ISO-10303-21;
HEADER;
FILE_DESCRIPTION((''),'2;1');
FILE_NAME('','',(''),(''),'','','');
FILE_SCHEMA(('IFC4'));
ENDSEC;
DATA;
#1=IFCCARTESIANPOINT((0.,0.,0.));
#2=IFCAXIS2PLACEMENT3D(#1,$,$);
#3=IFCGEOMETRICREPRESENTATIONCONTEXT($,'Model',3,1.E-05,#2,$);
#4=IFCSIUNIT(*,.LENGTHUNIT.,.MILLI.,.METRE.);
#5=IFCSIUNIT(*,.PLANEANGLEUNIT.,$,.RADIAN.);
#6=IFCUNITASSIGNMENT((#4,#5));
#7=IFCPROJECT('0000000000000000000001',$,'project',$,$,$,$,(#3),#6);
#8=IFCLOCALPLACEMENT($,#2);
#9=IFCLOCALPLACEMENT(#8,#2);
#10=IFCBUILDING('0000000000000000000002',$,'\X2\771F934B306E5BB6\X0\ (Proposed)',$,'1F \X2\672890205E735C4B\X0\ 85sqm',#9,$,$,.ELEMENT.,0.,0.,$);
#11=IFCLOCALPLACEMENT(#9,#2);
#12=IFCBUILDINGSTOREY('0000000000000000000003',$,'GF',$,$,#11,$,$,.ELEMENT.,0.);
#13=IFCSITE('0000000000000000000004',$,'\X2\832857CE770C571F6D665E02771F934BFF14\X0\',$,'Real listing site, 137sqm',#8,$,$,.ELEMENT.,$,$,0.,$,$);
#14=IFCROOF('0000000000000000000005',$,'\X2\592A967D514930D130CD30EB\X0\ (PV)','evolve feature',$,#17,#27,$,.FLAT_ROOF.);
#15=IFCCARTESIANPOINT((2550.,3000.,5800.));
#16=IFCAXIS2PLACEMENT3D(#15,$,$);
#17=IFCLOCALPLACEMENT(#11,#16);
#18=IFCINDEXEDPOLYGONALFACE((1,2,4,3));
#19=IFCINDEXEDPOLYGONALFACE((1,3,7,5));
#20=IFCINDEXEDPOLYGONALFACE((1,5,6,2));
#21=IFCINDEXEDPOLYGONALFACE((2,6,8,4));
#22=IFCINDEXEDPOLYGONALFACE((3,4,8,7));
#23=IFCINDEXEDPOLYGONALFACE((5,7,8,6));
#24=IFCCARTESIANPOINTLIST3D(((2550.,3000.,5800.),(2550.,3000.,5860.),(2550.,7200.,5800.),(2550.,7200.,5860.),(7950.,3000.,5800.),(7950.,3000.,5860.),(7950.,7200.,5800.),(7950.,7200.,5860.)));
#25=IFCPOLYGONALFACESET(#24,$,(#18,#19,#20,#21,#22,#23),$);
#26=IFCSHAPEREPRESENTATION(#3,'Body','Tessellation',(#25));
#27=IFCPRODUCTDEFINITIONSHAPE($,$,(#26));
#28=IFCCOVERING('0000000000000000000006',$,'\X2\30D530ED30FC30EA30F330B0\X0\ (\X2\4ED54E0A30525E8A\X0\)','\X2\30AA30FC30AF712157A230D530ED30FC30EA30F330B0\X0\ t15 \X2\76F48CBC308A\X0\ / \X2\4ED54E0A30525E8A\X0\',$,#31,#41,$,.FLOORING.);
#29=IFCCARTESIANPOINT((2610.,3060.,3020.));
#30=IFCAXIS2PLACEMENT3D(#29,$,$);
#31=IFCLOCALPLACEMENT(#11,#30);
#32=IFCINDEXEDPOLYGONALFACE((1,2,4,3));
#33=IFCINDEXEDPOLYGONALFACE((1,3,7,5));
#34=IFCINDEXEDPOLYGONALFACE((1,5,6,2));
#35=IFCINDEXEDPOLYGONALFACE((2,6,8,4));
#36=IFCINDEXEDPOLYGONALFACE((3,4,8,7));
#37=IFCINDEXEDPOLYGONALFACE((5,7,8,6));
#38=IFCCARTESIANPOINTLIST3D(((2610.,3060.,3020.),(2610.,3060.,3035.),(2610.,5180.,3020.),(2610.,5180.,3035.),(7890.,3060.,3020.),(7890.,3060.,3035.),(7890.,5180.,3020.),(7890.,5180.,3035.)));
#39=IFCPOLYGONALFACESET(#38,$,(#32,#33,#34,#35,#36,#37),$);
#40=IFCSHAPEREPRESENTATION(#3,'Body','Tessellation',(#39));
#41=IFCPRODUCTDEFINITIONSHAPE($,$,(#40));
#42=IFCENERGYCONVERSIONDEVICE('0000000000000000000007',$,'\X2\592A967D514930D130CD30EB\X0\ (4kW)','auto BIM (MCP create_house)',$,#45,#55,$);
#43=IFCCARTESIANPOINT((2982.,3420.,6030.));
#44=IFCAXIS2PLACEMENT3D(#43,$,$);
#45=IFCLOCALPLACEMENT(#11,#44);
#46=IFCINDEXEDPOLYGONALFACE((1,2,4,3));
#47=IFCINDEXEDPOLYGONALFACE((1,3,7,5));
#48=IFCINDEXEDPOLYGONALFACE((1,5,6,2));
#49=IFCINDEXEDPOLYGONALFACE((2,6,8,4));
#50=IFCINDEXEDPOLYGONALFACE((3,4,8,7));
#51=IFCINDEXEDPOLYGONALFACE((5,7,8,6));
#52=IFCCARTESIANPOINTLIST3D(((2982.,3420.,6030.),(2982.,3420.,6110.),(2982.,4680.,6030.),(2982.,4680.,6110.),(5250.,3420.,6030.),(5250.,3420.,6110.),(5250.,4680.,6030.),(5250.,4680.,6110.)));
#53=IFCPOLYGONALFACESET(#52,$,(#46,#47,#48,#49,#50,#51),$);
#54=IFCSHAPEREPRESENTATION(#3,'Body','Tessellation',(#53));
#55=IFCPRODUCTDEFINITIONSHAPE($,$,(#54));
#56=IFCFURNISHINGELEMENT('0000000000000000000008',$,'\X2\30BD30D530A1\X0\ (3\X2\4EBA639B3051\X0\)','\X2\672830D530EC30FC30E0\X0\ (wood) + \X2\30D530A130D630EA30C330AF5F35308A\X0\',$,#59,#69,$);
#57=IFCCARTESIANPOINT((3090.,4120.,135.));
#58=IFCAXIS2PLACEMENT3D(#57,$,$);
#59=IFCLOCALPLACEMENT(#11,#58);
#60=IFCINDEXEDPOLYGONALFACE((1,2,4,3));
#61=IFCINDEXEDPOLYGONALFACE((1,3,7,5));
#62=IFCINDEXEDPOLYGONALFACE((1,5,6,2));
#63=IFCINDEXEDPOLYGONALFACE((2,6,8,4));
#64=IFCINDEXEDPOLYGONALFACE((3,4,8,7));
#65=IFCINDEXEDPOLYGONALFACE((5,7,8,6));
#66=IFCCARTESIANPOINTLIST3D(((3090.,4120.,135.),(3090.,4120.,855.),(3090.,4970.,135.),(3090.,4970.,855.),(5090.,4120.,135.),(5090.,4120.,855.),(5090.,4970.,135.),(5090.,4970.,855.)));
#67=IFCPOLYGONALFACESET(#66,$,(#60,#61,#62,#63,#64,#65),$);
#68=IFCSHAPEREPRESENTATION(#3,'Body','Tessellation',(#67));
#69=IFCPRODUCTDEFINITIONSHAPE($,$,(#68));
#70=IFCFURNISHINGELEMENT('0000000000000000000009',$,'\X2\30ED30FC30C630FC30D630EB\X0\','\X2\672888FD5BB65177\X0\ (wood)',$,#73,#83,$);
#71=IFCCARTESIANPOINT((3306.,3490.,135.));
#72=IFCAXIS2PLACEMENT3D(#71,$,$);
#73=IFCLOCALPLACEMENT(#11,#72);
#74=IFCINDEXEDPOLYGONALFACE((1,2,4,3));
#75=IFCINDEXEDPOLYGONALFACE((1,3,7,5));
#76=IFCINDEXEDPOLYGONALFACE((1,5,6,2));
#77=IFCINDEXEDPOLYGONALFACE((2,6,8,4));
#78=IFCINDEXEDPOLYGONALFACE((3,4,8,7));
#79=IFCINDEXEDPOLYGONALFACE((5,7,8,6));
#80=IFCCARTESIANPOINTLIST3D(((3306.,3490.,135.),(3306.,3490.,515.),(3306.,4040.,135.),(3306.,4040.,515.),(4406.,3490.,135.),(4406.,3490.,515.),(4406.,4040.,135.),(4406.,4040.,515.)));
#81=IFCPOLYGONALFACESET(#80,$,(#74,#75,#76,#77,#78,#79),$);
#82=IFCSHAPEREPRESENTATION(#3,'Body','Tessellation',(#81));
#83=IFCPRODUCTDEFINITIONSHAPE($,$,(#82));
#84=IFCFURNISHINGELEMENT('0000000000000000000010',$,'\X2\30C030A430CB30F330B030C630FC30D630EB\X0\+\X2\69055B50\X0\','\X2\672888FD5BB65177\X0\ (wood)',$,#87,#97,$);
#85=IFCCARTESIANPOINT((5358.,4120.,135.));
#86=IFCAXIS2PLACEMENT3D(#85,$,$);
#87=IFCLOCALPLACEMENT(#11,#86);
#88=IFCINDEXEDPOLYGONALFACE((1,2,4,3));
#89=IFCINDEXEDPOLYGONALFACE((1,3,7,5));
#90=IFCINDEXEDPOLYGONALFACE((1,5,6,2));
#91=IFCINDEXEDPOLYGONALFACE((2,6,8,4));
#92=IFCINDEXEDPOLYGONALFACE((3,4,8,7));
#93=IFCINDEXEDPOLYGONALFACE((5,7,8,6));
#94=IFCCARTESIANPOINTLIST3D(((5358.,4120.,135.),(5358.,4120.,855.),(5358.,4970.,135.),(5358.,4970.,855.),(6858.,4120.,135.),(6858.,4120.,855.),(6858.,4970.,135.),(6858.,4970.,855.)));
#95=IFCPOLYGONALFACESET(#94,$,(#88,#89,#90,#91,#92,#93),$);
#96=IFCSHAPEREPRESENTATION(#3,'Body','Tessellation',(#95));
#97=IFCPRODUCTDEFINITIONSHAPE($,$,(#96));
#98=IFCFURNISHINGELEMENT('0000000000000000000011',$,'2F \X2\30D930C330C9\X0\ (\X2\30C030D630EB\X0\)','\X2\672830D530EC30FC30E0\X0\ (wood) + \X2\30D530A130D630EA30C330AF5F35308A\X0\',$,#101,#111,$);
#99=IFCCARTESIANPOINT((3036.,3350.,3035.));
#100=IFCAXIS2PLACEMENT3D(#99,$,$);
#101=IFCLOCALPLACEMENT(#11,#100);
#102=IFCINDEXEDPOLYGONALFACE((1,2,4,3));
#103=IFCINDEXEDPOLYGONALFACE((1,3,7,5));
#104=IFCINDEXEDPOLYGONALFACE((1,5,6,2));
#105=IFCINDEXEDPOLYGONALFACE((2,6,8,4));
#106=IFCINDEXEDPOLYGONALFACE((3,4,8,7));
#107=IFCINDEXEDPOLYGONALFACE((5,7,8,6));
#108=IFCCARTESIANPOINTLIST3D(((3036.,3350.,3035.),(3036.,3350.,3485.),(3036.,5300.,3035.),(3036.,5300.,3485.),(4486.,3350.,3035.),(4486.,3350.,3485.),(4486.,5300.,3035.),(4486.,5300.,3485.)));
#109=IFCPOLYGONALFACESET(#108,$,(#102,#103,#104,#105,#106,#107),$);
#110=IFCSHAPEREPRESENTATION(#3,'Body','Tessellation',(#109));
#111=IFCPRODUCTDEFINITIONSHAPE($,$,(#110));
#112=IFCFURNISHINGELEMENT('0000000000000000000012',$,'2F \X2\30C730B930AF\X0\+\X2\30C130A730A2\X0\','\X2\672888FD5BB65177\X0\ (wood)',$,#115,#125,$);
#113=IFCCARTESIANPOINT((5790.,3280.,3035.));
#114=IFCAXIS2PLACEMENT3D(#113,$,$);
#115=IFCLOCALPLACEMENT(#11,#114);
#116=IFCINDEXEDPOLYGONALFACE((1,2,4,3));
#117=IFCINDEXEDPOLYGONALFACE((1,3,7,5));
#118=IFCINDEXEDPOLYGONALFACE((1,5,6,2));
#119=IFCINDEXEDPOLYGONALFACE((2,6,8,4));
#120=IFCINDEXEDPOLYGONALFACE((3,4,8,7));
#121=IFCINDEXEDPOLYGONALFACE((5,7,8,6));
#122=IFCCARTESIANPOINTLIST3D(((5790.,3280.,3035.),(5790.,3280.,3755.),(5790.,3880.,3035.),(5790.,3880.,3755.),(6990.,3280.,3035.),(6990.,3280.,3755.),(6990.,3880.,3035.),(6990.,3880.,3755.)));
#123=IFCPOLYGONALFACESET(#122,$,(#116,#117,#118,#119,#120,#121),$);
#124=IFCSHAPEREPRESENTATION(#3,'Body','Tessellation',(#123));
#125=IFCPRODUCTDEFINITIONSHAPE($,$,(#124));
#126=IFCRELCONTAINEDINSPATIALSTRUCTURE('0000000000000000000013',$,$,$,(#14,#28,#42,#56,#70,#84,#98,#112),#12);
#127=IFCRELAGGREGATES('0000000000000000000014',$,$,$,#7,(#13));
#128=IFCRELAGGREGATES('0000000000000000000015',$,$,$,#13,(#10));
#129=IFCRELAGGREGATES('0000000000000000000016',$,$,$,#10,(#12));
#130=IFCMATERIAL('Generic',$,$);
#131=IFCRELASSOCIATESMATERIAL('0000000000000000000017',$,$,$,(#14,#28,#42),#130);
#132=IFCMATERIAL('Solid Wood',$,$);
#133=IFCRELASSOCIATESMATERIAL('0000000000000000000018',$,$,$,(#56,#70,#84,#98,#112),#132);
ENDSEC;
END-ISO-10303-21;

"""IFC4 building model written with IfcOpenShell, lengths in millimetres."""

from ifc_helpers import new_model, si_unit, frame, frame_2d, origin, place, context, project, spatial, rectangle, extrude, material, element, save


model = new_model("IFC4")

# Units and contexts
model_context = context("Model", 3, precision=1e-05, world=origin())
ifc_project = project(units=[si_unit("LENGTHUNIT", "METRE", prefix="MILLI"), si_unit("PLANEANGLEUNIT", "RADIAN")], contexts=[model_context])

# Site, building, storey
site_placement = place(None, origin())
site = spatial("IfcSite", under=ifc_project, at=site_placement, Name="茨城県土浦市真鍋４", ObjectType="Real listing site, 137sqm", CompositionType="ELEMENT", RefElevation=0.0)
building_placement = place(site_placement, origin())
building = spatial("IfcBuilding", under=site, at=building_placement, Name="真鍋の家 (Proposed)", ObjectType="1F 木造平屋 85sqm", CompositionType="ELEMENT", ElevationOfRefHeight=0.0, ElevationOfTerrain=0.0)
storey_placement = place(building_placement, origin())
storey = spatial("IfcBuildingStorey", under=building, at=storey_placement, Name="GF", CompositionType="ELEMENT", Elevation=0.0)

# Shared definitions
ifc_material_1 = material(Name="Solid Wood")

# Roof
ifc_material_2 = material(Name="Generic")
roof_1_placement = place(storey_placement, frame((2550.0, 3000.0, 5800.0)))
element("IfcRoof", 1, at=roof_1_placement, inside=storey, material=ifc_material_2, Name="太陽光パネル (PV)", Description="evolve feature", PredefinedType="FLAT_ROOF", context=model_context, shape_type="SweptSolid", body=[
    extrude(rectangle(XDim=5400.0, YDim=4200.0, at=frame_2d((2700.0, 2100.0))), frame((2550.0, 3000.0, 5800.0)), (0.0, 0.0, 1.0), 60.0),
])

# Covering
covering_placement = place(storey_placement, frame((2610.0, 3060.0, 3020.0)))
element("IfcCovering", 2, at=covering_placement, inside=storey, material=ifc_material_2, Name="フローリング (仕上げ床)", Description="オーク無垢フローリング t15 直貼り / 仕上げ床", PredefinedType="FLOORING", context=model_context, shape_type="SweptSolid", body=[
    extrude(rectangle(XDim=5280.0, YDim=2120.0, at=frame_2d((2640.0, 1060.0))), frame((2610.0, 3060.0, 3020.0)), (0.0, 0.0, 1.0), 15.0),
])

# Energy conversion device
energy_conversion_device_placement = place(storey_placement, frame((2982.0, 3420.0, 6030.0)))
element("IfcEnergyConversionDevice", 3, at=energy_conversion_device_placement, inside=storey, material=ifc_material_2, Name="太陽光パネル (4kW)", Description="auto BIM (MCP create_house)", context=model_context, shape_type="SweptSolid", body=[
    extrude(rectangle(XDim=2268.0, YDim=1260.0, at=frame_2d((1134.0, 630.0))), frame((2982.0, 3420.0, 6030.0)), (0.0, 0.0, 1.0), 80.0),
])

# Furnishing elements
furnishing_1_placement = place(storey_placement, frame((3090.0, 4120.0, 135.0)))
element("IfcFurnishingElement", 4, at=furnishing_1_placement, inside=storey, material=ifc_material_1, Name="ソファ (3人掛け)", Description="木フレーム (wood) + ファブリック張り", context=model_context, shape_type="SweptSolid", body=[
    extrude(rectangle(XDim=2000.0, YDim=850.0, at=frame_2d((1000.0, 425.0))), frame((3090.0, 4120.0, 135.0)), (0.0, 0.0, 1.0), 720.0),
])
furnishing_2_placement = place(storey_placement, frame((3306.0, 3490.0, 135.0)))
element("IfcFurnishingElement", 5, at=furnishing_2_placement, inside=storey, material=ifc_material_1, Name="ローテーブル", Description="木製家具 (wood)", context=model_context, shape_type="SweptSolid", body=[
    extrude(rectangle(XDim=1100.0, YDim=550.0, at=frame_2d((550.0, 275.0))), frame((3306.0, 3490.0, 135.0)), (0.0, 0.0, 1.0), 380.0),
])
furnishing_3_placement = place(storey_placement, frame((5358.0, 4120.0, 135.0)))
element("IfcFurnishingElement", 6, at=furnishing_3_placement, inside=storey, material=ifc_material_1, Name="ダイニングテーブル+椅子", Description="木製家具 (wood)", context=model_context, shape_type="SweptSolid", body=[
    extrude(rectangle(XDim=1500.0, YDim=850.0, at=frame_2d((750.0, 425.0))), frame((5358.0, 4120.0, 135.0)), (0.0, 0.0, 1.0), 720.0),
])
furnishing_4_placement = place(storey_placement, frame((3036.0, 3350.0, 3035.0)))
element("IfcFurnishingElement", 7, at=furnishing_4_placement, inside=storey, material=ifc_material_1, Name="2F ベッド (ダブル)", Description="木フレーム (wood) + ファブリック張り", context=model_context, shape_type="SweptSolid", body=[
    extrude(rectangle(XDim=1450.0, YDim=1950.0, at=frame_2d((725.0, 975.0))), frame((3036.0, 3350.0, 3035.0)), (0.0, 0.0, 1.0), 450.0),
])
furnishing_5_placement = place(storey_placement, frame((5790.0, 3280.0, 3035.0)))
element("IfcFurnishingElement", 8, at=furnishing_5_placement, inside=storey, material=ifc_material_1, Name="2F デスク+チェア", Description="木製家具 (wood)", context=model_context, shape_type="SweptSolid", body=[
    extrude(rectangle(XDim=1200.0, YDim=600.0, at=frame_2d((600.0, 300.0))), frame((5790.0, 3280.0, 3035.0)), (0.0, 0.0, 1.0), 720.0),
])

save(model, "model.ifc")
